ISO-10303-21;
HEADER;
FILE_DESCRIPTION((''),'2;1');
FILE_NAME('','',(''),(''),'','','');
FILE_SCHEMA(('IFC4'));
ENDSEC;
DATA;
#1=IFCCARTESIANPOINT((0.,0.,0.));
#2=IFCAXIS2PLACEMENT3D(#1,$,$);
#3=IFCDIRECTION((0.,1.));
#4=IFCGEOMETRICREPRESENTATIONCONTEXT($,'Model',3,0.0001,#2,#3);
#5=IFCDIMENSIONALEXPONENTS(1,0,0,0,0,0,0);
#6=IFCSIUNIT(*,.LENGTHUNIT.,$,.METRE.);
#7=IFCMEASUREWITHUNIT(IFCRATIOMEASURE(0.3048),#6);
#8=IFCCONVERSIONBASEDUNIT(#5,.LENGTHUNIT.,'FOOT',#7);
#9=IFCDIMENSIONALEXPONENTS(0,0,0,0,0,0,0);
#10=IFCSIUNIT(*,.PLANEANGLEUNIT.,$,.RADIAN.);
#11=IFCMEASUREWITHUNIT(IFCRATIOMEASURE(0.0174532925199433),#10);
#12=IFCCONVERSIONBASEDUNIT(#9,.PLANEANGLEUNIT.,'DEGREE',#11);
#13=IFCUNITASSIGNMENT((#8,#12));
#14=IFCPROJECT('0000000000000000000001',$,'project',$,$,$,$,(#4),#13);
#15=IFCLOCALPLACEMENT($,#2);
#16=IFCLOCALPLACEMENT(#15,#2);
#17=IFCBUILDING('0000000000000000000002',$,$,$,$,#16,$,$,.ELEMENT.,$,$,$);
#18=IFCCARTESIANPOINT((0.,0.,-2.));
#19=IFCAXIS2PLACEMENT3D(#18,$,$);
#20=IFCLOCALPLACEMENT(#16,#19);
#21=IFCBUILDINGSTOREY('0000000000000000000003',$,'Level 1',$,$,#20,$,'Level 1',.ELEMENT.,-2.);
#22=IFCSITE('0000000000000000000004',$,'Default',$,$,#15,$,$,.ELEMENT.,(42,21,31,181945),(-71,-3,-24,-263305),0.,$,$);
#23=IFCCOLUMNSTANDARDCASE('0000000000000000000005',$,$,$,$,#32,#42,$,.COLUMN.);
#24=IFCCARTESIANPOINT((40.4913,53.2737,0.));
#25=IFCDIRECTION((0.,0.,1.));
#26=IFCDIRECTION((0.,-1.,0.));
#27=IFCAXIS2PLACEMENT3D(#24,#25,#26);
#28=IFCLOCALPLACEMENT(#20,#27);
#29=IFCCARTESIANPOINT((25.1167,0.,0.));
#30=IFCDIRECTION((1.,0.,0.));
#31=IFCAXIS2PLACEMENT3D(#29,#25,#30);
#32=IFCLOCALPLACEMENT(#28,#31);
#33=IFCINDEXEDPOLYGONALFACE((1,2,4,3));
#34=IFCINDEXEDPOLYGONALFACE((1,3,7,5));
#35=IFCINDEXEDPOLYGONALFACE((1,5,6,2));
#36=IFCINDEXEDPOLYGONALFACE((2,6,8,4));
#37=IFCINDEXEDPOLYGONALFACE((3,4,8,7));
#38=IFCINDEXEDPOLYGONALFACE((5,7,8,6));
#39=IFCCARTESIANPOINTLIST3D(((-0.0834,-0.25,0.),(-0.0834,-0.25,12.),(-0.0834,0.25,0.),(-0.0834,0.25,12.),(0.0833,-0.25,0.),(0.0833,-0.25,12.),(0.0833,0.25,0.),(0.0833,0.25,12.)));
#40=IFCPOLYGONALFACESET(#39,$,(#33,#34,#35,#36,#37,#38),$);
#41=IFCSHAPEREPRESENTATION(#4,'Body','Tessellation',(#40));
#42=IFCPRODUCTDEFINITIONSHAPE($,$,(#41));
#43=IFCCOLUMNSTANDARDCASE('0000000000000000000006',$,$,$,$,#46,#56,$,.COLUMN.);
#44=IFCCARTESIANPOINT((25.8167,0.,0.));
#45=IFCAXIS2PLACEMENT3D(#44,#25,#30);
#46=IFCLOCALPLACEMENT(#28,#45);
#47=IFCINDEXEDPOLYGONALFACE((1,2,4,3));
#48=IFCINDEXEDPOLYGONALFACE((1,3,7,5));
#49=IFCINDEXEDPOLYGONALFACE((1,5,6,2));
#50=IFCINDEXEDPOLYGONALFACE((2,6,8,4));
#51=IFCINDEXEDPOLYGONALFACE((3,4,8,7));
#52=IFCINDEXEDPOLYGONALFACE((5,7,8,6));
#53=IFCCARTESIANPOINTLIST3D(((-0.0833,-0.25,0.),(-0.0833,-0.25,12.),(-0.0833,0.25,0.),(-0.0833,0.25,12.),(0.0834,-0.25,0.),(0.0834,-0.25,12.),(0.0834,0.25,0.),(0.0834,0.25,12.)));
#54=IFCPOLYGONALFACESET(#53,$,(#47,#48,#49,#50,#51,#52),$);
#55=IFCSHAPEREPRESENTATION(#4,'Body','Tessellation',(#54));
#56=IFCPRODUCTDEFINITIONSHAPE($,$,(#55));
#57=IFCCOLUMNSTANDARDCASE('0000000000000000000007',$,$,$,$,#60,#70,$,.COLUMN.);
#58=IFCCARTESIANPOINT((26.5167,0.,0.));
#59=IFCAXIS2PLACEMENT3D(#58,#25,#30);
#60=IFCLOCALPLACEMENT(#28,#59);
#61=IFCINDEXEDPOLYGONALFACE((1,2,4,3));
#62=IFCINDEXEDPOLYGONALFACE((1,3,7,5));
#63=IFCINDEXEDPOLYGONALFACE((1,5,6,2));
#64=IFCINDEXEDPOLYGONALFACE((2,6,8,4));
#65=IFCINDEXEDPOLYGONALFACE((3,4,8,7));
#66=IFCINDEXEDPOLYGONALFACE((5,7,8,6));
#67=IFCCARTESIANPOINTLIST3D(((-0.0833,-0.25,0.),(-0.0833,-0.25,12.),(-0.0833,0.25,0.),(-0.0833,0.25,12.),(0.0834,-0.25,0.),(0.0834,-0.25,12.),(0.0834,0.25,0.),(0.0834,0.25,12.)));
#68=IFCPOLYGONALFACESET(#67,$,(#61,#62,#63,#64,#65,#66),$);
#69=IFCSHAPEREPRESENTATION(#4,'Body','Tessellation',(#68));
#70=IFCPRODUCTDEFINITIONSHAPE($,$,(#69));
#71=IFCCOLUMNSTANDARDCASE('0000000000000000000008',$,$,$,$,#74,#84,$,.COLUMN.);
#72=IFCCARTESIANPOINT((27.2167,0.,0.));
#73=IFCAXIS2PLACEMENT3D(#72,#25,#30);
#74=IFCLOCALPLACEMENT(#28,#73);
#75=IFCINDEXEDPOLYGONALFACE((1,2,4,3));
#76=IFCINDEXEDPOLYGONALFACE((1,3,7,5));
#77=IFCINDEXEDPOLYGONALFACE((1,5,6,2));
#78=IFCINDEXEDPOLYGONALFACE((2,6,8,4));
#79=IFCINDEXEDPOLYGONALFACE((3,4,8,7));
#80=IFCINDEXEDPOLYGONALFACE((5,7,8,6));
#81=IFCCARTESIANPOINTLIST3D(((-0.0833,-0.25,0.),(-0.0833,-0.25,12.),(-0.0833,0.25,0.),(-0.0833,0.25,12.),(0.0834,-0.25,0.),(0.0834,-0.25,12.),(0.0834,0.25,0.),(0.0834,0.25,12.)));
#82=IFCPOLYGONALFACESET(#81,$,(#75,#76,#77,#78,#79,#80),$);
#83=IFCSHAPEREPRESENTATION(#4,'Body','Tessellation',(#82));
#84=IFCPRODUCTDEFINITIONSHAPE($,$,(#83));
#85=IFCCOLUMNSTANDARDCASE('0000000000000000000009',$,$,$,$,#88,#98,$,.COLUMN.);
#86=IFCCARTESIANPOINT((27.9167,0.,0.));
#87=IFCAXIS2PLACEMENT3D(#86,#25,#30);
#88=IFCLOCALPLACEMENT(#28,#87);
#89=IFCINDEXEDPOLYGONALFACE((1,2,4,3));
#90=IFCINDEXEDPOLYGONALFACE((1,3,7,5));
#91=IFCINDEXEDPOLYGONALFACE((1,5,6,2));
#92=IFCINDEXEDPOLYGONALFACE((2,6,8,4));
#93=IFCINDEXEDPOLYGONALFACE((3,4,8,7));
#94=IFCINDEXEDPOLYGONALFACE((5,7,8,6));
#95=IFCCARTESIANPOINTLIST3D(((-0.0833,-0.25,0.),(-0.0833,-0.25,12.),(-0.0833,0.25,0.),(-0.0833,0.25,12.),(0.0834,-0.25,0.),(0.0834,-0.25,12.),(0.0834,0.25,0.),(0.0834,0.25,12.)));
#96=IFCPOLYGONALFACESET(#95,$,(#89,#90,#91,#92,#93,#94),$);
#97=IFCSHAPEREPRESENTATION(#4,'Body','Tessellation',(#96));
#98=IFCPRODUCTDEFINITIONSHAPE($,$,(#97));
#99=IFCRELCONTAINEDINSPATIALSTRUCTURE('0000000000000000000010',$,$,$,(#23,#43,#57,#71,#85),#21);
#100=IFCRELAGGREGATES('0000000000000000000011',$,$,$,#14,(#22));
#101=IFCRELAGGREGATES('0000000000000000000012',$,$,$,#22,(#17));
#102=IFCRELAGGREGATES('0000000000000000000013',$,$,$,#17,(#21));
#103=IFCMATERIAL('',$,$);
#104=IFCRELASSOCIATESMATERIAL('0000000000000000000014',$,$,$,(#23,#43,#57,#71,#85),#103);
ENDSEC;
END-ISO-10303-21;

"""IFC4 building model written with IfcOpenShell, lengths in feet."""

from ifc_helpers import new_model, entity, si_unit, converted_unit, direction, frame, origin, place, context, project, spatial, rectangle, extrude, material, element, save


model = new_model("IFC4")

# Units and contexts
model_context = context("Model", 3, precision=0.0001, world=origin(), true_north=direction((0.0, 1.0)))
ifc_project = project(units=[converted_unit("LENGTHUNIT", "FOOT", entity("IfcRatioMeasure", 0.3048), si_unit("LENGTHUNIT", "METRE"), dimensions=[1, 0, 0, 0, 0, 0, 0]), converted_unit("PLANEANGLEUNIT", "DEGREE", entity("IfcRatioMeasure", 0.0174532925199433), si_unit("PLANEANGLEUNIT", "RADIAN"), dimensions=[0, 0, 0, 0, 0, 0, 0])], contexts=[model_context])

# Site, building, storey
site_placement = place(None, origin())
site = spatial("IfcSite", under=ifc_project, at=site_placement, Name="Default", CompositionType="ELEMENT", RefLatitude=(42, 21, 31, 181945), RefLongitude=(-71, -3, -24, -263305), RefElevation=0.0)
building_placement = place(site_placement, origin())
building = spatial("IfcBuilding", under=site, at=building_placement, CompositionType="ELEMENT")
storey_placement = place(building_placement, frame((0.0, 0.0, -2.0)))
storey = spatial("IfcBuildingStorey", under=building, at=storey_placement, Name="Level 1", LongName="Level 1", CompositionType="ELEMENT", Elevation=-2.0)

# Columns
ifc_material_1 = material(Name="")
placement = place(storey_placement, frame((40.4913, 53.2737, 0.0), z_axis=(0.0, 0.0, 1.0), x_axis=(0.0, -1.0, 0.0)))
for number, where, z_axis, x_axis in (
    (1, (25.1167, 0.0, 0.0), (0.0, 0.0, 1.0), (1.0, 0.0, 0.0)),
    (2, (25.8167, 0.0, 0.0), (0.0, 0.0, 1.0), (1.0, 0.0, 0.0)),
    (3, (26.5167, 0.0, 0.0), (0.0, 0.0, 1.0), (1.0, 0.0, 0.0)),
    (4, (27.2167, 0.0, 0.0), (0.0, 0.0, 1.0), (1.0, 0.0, 0.0)),
    (5, (27.9167, 0.0, 0.0), (0.0, 0.0, 1.0), (1.0, 0.0, 0.0)),
):
    element("IfcColumnStandardCase", number, at=place(placement, frame(where, z_axis=z_axis, x_axis=x_axis)), inside=storey, material=ifc_material_1, PredefinedType="COLUMN", context=model_context, shape_type="SweptSolid", body=[
        extrude(rectangle(XDim=0.1667, YDim=0.5), origin(), (0.0, 0.0, 1.0), 12.0),
    ])

save(model, "model.ifc")
